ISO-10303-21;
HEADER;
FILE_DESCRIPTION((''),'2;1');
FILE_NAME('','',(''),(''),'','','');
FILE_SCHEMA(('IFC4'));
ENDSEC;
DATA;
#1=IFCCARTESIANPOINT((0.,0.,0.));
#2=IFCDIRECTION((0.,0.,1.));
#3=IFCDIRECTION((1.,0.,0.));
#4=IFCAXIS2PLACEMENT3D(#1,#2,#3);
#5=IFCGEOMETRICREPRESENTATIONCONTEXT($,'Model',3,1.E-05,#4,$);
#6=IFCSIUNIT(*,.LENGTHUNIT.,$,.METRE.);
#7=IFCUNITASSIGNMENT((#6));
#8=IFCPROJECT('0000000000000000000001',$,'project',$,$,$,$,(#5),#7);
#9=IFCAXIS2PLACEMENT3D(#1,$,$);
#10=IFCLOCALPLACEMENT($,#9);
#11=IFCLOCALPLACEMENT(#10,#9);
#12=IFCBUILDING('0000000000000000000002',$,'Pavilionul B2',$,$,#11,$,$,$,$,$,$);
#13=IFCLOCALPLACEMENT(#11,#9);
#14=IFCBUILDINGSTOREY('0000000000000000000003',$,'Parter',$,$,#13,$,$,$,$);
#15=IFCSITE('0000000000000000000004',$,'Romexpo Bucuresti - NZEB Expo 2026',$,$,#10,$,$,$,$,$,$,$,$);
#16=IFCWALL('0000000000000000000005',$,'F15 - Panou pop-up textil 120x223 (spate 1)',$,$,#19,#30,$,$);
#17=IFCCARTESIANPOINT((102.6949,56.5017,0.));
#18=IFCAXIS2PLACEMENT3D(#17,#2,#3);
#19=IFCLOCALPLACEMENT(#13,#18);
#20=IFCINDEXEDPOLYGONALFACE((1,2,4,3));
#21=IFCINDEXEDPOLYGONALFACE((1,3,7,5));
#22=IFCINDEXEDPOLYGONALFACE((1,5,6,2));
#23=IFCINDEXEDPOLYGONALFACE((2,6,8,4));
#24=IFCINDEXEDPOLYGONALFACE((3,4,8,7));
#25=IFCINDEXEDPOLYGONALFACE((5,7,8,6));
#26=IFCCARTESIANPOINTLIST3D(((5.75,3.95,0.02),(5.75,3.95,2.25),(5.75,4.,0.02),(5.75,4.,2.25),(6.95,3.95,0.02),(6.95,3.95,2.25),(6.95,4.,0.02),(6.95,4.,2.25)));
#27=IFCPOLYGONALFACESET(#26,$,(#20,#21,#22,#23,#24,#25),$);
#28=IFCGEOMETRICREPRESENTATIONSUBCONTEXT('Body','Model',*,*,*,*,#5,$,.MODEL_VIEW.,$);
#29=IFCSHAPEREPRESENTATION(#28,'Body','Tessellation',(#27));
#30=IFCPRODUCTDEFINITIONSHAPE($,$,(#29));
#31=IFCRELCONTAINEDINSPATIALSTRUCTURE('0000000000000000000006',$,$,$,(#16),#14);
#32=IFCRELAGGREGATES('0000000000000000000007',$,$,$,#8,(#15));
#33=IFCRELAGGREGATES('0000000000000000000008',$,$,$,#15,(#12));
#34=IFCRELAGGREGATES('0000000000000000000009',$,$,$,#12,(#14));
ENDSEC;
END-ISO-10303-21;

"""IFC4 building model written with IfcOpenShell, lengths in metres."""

from ifc_helpers import new_model, si_unit, frame, frame_2d, origin, origin_with_axes, place, context, subcontext, project, spatial, rectangle, extrude, element, save


model = new_model("IFC4")

# Units and contexts
model_context = context("Model", 3, precision=1e-05, world=origin_with_axes())
body_context = subcontext(model_context, "Body", "Model", "MODEL_VIEW")
ifc_project = project(units=[si_unit("LENGTHUNIT", "METRE")], contexts=[model_context])

# Site, building, storey
site_placement = place(None, origin())
site = spatial("IfcSite", under=ifc_project, at=site_placement, Name="Romexpo Bucuresti - NZEB Expo 2026")
building_placement = place(site_placement, origin())
building = spatial("IfcBuilding", under=site, at=building_placement, Name="Pavilionul B2")
storey_placement = place(building_placement, origin())
storey = spatial("IfcBuildingStorey", under=building, at=storey_placement, Name="Parter")

# Wall
wall_placement = place(storey_placement, frame((102.6949, 56.5017, 0.0), z_axis=(0.0, 0.0, 1.0), x_axis=(1.0, 0.0, 0.0)))
element("IfcWall", 1, at=wall_placement, inside=storey, Name="F15 - Panou pop-up textil 120x223 (spate 1)", context=body_context, shape_type="SweptSolid", body=[
    extrude(rectangle(XDim=1.2, YDim=0.05, at=frame_2d((6.35, 3.975))), frame((0.0, 0.0, 0.02)), (0.0, 0.0, 1.0), 2.23),
])

save(model, "model.ifc")
